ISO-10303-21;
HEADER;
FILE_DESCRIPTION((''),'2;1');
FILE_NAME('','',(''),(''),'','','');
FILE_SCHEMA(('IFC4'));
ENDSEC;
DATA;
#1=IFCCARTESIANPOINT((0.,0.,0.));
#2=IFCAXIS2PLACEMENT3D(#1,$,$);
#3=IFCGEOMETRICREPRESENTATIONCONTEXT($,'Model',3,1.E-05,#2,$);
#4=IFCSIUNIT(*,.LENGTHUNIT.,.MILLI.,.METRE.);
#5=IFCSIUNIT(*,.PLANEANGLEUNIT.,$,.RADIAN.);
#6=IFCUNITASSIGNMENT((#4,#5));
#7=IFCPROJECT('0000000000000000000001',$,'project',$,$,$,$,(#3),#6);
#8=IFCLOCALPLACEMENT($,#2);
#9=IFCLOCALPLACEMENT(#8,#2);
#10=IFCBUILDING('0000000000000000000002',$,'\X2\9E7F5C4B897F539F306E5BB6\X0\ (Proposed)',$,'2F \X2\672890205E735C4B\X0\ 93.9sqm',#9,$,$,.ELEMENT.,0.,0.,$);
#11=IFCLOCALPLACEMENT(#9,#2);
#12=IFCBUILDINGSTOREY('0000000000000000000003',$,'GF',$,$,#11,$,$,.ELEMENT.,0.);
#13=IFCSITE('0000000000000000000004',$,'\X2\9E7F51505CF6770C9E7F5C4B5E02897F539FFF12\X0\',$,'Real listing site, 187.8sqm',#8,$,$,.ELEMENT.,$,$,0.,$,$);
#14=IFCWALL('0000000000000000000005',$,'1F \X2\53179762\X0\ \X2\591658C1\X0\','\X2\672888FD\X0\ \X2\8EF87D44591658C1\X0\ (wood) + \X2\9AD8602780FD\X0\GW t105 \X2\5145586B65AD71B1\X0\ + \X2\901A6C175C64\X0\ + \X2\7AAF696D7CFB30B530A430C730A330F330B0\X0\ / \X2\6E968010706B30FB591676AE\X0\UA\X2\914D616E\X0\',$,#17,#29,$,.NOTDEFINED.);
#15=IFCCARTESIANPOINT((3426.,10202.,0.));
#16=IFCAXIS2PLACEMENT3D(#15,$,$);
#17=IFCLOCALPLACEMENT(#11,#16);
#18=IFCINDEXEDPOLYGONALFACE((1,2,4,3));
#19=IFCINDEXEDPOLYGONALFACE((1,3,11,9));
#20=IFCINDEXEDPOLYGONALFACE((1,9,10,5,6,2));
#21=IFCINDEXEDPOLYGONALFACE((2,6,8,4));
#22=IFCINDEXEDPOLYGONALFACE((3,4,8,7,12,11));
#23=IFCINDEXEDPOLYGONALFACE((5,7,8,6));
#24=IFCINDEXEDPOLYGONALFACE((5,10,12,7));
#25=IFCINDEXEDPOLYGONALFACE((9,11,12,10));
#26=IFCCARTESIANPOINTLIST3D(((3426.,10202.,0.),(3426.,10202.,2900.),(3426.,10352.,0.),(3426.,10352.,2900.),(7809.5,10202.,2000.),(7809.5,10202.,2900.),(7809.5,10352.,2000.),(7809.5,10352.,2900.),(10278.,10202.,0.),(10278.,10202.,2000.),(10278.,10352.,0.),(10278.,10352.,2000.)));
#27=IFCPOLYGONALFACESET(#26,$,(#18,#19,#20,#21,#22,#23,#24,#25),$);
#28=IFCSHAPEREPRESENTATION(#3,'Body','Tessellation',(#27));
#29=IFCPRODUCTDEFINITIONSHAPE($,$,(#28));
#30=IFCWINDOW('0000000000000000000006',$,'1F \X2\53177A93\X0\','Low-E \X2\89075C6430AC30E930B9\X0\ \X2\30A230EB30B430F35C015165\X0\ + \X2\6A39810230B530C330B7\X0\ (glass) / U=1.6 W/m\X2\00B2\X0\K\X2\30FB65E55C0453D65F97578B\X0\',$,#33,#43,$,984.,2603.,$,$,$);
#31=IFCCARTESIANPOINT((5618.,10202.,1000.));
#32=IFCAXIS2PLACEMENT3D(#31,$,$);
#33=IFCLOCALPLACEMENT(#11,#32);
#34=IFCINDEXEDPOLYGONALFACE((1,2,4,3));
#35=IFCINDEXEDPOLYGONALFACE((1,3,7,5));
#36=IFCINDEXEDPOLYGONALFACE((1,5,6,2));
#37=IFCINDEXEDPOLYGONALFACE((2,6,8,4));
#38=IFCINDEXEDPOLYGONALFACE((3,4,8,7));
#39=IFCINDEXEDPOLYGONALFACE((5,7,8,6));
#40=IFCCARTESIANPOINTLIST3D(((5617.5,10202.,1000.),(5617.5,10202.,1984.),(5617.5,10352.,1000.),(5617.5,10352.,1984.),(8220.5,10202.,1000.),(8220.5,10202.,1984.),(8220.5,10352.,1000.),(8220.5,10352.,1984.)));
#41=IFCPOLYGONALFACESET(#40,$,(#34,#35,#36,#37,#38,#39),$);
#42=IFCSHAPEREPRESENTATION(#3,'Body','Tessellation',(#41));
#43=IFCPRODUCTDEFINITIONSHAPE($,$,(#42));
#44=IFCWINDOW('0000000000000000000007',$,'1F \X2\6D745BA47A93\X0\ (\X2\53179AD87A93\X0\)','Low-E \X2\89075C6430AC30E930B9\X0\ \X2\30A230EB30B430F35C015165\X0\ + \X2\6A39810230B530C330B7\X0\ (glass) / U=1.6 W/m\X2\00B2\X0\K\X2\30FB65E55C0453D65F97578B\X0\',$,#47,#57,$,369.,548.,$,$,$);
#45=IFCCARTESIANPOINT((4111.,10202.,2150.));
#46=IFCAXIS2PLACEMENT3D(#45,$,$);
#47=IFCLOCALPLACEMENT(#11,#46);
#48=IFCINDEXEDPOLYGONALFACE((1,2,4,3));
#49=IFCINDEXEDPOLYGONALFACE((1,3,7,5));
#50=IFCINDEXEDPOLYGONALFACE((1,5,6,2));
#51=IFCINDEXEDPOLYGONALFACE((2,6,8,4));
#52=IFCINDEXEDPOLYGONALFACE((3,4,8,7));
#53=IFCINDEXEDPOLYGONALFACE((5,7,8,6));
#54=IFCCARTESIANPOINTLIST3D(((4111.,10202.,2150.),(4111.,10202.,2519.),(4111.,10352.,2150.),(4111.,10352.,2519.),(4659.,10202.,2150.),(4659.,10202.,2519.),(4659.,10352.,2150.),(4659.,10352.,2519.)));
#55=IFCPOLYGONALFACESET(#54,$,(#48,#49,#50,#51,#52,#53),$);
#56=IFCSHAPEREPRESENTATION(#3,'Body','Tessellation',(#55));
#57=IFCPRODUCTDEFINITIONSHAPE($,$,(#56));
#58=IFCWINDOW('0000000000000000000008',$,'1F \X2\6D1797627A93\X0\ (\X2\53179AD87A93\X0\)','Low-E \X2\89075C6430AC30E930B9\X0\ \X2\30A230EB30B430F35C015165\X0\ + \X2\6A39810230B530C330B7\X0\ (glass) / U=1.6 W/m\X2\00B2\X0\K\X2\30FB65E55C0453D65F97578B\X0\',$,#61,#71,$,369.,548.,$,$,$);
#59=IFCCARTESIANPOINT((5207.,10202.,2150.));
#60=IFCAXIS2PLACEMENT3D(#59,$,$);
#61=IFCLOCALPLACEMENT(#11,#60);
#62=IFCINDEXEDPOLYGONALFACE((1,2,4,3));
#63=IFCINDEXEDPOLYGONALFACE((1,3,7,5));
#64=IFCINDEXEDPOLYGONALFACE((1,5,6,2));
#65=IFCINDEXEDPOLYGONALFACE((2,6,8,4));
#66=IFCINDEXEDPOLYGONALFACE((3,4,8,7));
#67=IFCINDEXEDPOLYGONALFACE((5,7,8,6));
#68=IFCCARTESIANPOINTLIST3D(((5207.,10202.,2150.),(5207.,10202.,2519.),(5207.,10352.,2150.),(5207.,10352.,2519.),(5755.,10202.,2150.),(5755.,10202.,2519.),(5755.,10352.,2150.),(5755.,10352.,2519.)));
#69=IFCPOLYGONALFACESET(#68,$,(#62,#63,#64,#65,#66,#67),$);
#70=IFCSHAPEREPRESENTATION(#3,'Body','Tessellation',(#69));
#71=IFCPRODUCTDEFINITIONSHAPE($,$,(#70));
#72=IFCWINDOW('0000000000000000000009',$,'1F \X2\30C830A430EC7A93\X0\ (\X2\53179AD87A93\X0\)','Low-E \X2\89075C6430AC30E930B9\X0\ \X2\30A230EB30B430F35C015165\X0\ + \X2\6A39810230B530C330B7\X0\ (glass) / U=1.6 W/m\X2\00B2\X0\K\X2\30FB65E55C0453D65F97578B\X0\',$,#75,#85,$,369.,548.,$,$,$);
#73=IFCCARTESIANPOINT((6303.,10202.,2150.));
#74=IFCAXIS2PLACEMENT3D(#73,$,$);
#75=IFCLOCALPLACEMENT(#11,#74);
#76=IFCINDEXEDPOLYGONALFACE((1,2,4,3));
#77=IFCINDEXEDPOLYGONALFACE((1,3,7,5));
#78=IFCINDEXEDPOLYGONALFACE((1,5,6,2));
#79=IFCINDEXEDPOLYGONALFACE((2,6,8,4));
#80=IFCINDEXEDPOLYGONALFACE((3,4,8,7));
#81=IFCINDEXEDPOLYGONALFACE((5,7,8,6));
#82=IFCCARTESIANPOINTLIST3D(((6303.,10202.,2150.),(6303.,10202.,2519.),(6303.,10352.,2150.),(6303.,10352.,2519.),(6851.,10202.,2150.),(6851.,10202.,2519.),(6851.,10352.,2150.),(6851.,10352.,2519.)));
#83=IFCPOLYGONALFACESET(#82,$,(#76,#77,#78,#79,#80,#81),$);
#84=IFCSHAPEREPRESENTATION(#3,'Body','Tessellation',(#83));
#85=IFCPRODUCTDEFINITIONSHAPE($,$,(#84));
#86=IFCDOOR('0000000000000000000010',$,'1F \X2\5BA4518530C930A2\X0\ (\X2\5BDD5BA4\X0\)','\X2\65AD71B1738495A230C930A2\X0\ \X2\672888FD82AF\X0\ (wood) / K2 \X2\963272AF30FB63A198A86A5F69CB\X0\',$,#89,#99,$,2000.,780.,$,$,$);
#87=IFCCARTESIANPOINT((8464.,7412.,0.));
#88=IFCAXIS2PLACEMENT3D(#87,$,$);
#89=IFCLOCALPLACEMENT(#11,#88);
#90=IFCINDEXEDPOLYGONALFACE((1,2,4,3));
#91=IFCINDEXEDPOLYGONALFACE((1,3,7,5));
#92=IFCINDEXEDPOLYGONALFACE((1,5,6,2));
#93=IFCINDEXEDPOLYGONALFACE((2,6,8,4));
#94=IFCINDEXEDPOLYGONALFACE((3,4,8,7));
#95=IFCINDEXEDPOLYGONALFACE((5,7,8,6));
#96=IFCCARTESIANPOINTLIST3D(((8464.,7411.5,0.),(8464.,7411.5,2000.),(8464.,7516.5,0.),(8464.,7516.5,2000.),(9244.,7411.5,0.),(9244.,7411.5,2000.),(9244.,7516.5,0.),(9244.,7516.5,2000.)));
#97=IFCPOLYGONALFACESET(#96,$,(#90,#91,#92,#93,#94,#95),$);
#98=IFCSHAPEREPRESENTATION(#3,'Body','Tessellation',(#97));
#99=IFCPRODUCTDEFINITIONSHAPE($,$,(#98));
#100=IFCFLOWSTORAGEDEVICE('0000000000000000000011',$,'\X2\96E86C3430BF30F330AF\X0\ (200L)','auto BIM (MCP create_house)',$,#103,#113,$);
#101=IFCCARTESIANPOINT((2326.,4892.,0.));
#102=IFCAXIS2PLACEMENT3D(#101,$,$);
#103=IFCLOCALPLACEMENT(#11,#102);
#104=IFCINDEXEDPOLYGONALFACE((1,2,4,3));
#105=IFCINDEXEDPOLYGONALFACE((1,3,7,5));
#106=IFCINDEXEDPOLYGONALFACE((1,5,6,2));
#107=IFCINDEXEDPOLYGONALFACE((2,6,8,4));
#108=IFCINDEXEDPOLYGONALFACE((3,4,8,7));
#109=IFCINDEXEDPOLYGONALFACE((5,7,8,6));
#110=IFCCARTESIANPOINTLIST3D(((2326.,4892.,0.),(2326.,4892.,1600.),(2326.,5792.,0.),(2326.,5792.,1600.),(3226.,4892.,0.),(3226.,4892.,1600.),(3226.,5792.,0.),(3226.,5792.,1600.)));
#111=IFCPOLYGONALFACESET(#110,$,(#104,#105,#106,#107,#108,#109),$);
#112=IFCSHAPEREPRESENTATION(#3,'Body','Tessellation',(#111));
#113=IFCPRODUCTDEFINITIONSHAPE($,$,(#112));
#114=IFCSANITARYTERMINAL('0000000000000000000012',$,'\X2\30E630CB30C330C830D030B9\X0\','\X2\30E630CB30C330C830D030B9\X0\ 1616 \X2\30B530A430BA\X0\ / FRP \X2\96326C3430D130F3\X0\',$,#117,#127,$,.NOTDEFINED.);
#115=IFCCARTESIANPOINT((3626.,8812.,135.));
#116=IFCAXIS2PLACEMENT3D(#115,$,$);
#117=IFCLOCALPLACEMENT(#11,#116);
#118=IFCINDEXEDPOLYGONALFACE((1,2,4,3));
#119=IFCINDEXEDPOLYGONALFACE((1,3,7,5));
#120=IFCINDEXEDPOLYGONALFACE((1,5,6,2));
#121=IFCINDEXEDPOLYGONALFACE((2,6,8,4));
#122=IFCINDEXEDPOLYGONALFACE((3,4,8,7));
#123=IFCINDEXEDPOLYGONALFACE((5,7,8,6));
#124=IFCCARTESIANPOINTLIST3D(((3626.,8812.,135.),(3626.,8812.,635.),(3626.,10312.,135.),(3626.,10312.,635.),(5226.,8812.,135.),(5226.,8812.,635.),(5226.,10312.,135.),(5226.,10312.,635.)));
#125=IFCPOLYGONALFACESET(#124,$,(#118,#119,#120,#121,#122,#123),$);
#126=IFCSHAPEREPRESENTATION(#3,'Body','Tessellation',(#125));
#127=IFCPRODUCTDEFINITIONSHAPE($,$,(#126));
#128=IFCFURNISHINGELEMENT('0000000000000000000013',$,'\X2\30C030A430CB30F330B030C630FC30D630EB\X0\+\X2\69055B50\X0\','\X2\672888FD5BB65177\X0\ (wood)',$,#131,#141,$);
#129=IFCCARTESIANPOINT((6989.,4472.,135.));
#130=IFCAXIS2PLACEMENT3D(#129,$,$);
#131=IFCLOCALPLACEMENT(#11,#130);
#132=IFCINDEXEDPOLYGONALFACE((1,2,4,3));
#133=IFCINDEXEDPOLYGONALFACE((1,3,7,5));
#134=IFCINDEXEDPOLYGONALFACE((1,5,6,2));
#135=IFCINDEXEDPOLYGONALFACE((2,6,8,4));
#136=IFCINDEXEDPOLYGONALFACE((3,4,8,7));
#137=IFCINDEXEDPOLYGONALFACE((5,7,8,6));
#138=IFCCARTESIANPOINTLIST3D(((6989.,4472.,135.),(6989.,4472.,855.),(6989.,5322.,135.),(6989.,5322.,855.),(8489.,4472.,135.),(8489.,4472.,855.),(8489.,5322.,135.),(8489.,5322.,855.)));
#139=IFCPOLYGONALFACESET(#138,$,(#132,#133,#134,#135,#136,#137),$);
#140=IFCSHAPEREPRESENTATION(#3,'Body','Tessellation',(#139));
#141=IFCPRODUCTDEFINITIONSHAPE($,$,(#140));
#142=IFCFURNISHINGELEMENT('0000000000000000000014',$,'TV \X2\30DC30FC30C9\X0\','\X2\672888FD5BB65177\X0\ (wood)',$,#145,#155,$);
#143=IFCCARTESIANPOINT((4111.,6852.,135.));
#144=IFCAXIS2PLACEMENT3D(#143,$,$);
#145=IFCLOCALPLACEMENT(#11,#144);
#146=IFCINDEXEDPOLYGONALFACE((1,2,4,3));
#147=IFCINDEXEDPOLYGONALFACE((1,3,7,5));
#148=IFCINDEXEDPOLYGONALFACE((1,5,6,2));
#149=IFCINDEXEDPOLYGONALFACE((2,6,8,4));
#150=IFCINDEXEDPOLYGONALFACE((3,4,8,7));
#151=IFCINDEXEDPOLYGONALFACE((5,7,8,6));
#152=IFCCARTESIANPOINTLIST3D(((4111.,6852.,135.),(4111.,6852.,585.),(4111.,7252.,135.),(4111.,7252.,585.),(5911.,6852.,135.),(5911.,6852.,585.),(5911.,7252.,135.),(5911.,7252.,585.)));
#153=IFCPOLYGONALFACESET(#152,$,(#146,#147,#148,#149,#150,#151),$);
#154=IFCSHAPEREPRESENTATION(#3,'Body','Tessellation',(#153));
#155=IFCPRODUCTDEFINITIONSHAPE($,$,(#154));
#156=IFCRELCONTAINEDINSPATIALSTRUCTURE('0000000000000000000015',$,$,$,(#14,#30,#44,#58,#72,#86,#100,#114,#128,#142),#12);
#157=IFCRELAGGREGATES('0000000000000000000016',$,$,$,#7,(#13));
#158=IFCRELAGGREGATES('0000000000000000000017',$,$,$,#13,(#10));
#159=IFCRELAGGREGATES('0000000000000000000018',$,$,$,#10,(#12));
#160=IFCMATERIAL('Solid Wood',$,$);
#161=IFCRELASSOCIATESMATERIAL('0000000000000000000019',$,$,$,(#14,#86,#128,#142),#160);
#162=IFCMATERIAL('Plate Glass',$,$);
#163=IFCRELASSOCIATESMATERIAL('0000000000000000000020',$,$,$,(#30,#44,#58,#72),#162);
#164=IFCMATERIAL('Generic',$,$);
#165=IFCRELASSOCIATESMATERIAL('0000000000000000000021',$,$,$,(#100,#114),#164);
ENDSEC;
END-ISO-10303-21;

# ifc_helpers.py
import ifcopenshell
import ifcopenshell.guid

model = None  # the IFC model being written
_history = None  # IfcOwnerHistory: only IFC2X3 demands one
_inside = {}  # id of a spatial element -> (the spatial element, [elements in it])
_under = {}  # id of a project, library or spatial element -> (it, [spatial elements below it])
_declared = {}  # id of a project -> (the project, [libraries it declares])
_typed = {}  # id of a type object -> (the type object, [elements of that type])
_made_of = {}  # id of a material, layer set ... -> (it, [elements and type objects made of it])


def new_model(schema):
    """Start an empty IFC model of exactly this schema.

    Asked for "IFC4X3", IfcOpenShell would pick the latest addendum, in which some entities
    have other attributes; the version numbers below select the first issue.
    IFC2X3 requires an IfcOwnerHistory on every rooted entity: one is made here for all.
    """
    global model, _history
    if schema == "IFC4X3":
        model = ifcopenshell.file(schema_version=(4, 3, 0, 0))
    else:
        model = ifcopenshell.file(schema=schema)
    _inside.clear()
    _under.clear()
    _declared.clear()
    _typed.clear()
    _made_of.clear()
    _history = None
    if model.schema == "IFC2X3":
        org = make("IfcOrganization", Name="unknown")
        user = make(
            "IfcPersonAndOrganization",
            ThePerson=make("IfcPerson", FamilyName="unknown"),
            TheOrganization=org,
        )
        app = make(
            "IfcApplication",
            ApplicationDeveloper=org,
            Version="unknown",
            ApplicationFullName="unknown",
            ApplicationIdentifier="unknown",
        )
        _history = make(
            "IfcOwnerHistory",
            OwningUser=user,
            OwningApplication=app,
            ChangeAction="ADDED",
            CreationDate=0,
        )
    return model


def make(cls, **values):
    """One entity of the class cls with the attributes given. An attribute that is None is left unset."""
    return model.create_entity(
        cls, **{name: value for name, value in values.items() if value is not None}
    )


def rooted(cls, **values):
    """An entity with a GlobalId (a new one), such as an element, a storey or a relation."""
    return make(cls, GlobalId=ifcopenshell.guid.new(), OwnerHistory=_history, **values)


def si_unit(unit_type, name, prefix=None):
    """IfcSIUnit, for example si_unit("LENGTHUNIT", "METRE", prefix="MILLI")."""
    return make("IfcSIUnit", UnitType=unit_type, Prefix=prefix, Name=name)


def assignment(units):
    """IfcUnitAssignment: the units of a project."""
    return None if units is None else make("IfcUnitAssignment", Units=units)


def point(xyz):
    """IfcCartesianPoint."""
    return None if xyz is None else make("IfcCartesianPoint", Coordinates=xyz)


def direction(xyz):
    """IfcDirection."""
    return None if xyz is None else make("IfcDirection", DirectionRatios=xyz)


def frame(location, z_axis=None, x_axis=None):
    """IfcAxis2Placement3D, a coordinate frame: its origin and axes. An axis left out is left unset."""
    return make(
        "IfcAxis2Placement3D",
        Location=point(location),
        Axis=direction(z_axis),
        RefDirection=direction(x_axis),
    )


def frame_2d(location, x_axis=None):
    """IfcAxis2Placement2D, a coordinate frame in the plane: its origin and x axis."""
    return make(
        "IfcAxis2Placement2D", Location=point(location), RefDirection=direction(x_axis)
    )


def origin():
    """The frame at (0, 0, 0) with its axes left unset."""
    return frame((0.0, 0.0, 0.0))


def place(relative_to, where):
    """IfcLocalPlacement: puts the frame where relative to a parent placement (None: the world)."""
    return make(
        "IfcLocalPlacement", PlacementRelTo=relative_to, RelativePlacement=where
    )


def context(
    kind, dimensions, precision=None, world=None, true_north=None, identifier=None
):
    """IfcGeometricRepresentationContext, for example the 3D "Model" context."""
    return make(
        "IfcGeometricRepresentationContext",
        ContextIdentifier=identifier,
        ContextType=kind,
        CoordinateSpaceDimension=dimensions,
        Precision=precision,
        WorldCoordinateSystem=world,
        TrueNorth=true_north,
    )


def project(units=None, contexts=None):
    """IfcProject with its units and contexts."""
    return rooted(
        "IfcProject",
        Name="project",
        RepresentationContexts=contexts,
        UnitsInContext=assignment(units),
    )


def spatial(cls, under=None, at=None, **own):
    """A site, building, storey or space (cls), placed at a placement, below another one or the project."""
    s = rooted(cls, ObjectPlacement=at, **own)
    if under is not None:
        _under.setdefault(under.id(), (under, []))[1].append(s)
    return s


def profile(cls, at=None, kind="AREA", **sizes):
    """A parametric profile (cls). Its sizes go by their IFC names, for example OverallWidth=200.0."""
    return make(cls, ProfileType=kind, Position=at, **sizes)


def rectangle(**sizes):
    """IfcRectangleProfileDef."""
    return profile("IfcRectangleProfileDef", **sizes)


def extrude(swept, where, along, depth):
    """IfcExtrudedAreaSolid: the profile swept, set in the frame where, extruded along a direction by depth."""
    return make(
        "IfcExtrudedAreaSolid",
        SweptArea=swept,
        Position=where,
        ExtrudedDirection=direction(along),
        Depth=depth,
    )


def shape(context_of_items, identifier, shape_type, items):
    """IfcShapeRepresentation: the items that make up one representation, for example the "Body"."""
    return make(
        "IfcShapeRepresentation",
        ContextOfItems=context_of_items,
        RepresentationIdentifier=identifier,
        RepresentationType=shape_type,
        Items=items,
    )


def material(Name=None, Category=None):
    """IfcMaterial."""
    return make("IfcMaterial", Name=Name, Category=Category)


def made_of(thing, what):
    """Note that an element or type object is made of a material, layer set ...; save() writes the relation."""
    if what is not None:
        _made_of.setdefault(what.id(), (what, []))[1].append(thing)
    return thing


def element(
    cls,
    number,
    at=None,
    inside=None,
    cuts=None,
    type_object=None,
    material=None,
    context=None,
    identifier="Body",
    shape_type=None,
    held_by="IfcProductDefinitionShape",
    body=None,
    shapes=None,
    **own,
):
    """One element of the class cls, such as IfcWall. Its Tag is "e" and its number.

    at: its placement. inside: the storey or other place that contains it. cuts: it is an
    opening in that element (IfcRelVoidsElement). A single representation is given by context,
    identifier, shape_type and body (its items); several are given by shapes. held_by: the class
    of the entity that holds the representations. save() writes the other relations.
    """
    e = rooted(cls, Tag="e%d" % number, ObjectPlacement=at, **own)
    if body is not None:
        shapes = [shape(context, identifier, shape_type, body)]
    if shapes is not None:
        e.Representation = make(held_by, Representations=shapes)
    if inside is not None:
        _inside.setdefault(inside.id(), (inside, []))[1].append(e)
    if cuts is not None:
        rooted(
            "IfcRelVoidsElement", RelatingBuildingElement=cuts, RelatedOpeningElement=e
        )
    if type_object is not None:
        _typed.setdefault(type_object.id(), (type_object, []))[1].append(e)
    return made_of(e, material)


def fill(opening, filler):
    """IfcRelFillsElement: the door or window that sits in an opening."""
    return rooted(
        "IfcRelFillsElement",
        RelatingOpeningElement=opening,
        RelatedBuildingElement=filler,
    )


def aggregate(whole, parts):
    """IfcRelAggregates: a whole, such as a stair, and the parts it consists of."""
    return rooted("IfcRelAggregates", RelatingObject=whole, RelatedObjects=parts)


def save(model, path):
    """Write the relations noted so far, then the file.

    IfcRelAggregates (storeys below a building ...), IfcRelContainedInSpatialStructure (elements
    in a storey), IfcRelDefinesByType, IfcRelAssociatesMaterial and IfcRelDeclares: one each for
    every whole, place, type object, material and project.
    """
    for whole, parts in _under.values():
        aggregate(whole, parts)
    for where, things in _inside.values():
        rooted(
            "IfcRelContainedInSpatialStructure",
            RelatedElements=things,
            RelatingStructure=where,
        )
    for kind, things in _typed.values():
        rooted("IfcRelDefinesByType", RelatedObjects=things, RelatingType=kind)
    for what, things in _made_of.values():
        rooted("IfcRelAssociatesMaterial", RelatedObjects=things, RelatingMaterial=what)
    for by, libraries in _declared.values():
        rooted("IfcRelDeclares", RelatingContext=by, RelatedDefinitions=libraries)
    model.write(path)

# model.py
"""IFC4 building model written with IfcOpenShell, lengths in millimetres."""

from ifc_helpers import new_model, si_unit, frame, frame_2d, origin, place, context, project, spatial, rectangle, extrude, material, element, fill, save


model = new_model("IFC4")

# Units and contexts
model_context = context("Model", 3, precision=1e-05, world=origin())
ifc_project = project(units=[si_unit("LENGTHUNIT", "METRE", prefix="MILLI"), si_unit("PLANEANGLEUNIT", "RADIAN")], contexts=[model_context])

# Site, building, storey
site_placement = place(None, origin())
site = spatial("IfcSite", under=ifc_project, at=site_placement, Name="鹿児島県鹿屋市西原２", ObjectType="Real listing site, 187.8sqm", CompositionType="ELEMENT", RefElevation=0.0)
building_placement = place(site_placement, origin())
building = spatial("IfcBuilding", under=site, at=building_placement, Name="鹿屋西原の家 (Proposed)", ObjectType="2F 木造平屋 93.9sqm", CompositionType="ELEMENT", ElevationOfRefHeight=0.0, ElevationOfTerrain=0.0)
storey_placement = place(building_placement, origin())
storey = spatial("IfcBuildingStorey", under=building, at=storey_placement, Name="GF", CompositionType="ELEMENT", Elevation=0.0)

# Wall, openings, windows
ifc_material_1 = material(Name="Solid Wood")
wall_1_placement = place(storey_placement, frame((3426.0, 10202.0, 0.0)))
wall_1 = element("IfcWall", 1, at=wall_1_placement, inside=storey, material=ifc_material_1, Name="1F 北面 外壁", Description="木製 軸組外壁 (wood) + 高性能GW t105 充填断熱 + 通気層 + 窯業系サイディング / 準耐火・外皮UA配慮", PredefinedType="NOTDEFINED", context=model_context, shape_type="SweptSolid", body=[
    extrude(rectangle(XDim=6852.0, YDim=150.0, at=frame_2d((3426.0, 75.0))), frame((3426.0, 10202.0, 0.0)), (0.0, 0.0, 1.0), 2900.0),
])
opening_1_placement = place(storey_placement, frame((5618.0, 10202.0, 1000.0)))
opening_1 = element("IfcOpeningElement", 2, at=opening_1_placement, cuts=wall_1, PredefinedType="NOTDEFINED", context=model_context, shape_type="SweptSolid", body=[
    extrude(rectangle(XDim=2603.0, YDim=150.0, at=frame_2d((1301.0, 75.0))), frame((5618.0, 10202.0, 1000.0)), (0.0, 0.0, 1.0), 984.0),
])
opening_2_placement = place(storey_placement, frame((4111.0, 10202.0, 2150.0)))
opening_2 = element("IfcOpeningElement", 3, at=opening_2_placement, cuts=wall_1, PredefinedType="NOTDEFINED", context=model_context, shape_type="SweptSolid", body=[
    extrude(rectangle(XDim=548.0, YDim=150.0, at=frame_2d((274.0, 75.0))), frame((4111.0, 10202.0, 2150.0)), (0.0, 0.0, 1.0), 369.0),
])
opening_3_placement = place(storey_placement, frame((5207.0, 10202.0, 2150.0)))
opening_3 = element("IfcOpeningElement", 4, at=opening_3_placement, cuts=wall_1, PredefinedType="NOTDEFINED", context=model_context, shape_type="SweptSolid", body=[
    extrude(rectangle(XDim=548.0, YDim=150.0, at=frame_2d((274.0, 75.0))), frame((5207.0, 10202.0, 2150.0)), (0.0, 0.0, 1.0), 369.0),
])
opening_4_placement = place(storey_placement, frame((6303.0, 10202.0, 2150.0)))
opening_4 = element("IfcOpeningElement", 5, at=opening_4_placement, cuts=wall_1, PredefinedType="NOTDEFINED", context=model_context, shape_type="SweptSolid", body=[
    extrude(rectangle(XDim=548.0, YDim=150.0, at=frame_2d((274.0, 75.0))), frame((6303.0, 10202.0, 2150.0)), (0.0, 0.0, 1.0), 369.0),
])
ifc_material_2 = material(Name="Plate Glass")
window_1_placement = place(storey_placement, frame((5618.0, 10202.0, 1000.0)))
window_1 = element("IfcWindow", 6, at=window_1_placement, inside=storey, material=ifc_material_2, Name="1F 北窓", Description="Low-E 複層ガラス アルゴン封入 + 樹脂サッシ (glass) / U=1.6 W/m²K・日射取得型", OverallHeight=984.0, OverallWidth=2603.0, context=model_context, shape_type="SweptSolid", body=[
    extrude(rectangle(XDim=2603.0, YDim=150.0, at=frame_2d((1301.0, 75.0))), frame((5618.0, 10202.0, 1000.0)), (0.0, 0.0, 1.0), 984.0),
])
fill(opening_1, window_1)
window_2_placement = place(storey_placement, frame((4111.0, 10202.0, 2150.0)))
window_2 = element("IfcWindow", 7, at=window_2_placement, inside=storey, material=ifc_material_2, Name="1F 浴室窓 (北高窓)", Description="Low-E 複層ガラス アルゴン封入 + 樹脂サッシ (glass) / U=1.6 W/m²K・日射取得型", OverallHeight=369.0, OverallWidth=548.0, context=model_context, shape_type="SweptSolid", body=[
    extrude(rectangle(XDim=548.0, YDim=150.0, at=frame_2d((274.0, 75.0))), frame((4111.0, 10202.0, 2150.0)), (0.0, 0.0, 1.0), 369.0),
])
fill(opening_2, window_2)
window_3_placement = place(storey_placement, frame((5207.0, 10202.0, 2150.0)))
window_3 = element("IfcWindow", 8, at=window_3_placement, inside=storey, material=ifc_material_2, Name="1F 洗面窓 (北高窓)", Description="Low-E 複層ガラス アルゴン封入 + 樹脂サッシ (glass) / U=1.6 W/m²K・日射取得型", OverallHeight=369.0, OverallWidth=548.0, context=model_context, shape_type="SweptSolid", body=[
    extrude(rectangle(XDim=548.0, YDim=150.0, at=frame_2d((274.0, 75.0))), frame((5207.0, 10202.0, 2150.0)), (0.0, 0.0, 1.0), 369.0),
])
fill(opening_3, window_3)
window_4_placement = place(storey_placement, frame((6303.0, 10202.0, 2150.0)))
window_4 = element("IfcWindow", 9, at=window_4_placement, inside=storey, material=ifc_material_2, Name="1F トイレ窓 (北高窓)", Description="Low-E 複層ガラス アルゴン封入 + 樹脂サッシ (glass) / U=1.6 W/m²K・日射取得型", OverallHeight=369.0, OverallWidth=548.0, context=model_context, shape_type="SweptSolid", body=[
    extrude(rectangle(XDim=548.0, YDim=150.0, at=frame_2d((274.0, 75.0))), frame((6303.0, 10202.0, 2150.0)), (0.0, 0.0, 1.0), 369.0),
])
fill(opening_4, window_4)

# Door
door_1_placement = place(storey_placement, frame((8464.0, 7412.0, 0.0)))
element("IfcDoor", 10, at=door_1_placement, inside=storey, material=ifc_material_1, Name="1F 室内ドア (寝室)", Description="断熱玄関ドア 木製芯 (wood) / K2 防犯・採風機構", OverallHeight=2000.0, OverallWidth=780.0, context=model_context, shape_type="SweptSolid", body=[
    extrude(rectangle(XDim=780.0, YDim=105.0, at=frame_2d((390.0, 52.0))), frame((8464.0, 7412.0, 0.0)), (0.0, 0.0, 1.0), 2000.0),
])

# Flow storage device
ifc_material_3 = material(Name="Generic")
flow_storage_device_placement = place(storey_placement, frame((2326.0, 4892.0, 0.0)))
element("IfcFlowStorageDevice", 11, at=flow_storage_device_placement, inside=storey, material=ifc_material_3, Name="雨水タンク (200L)", Description="auto BIM (MCP create_house)", context=model_context, shape_type="SweptSolid", body=[
    extrude(rectangle(XDim=900.0, YDim=900.0, at=frame_2d((450.0, 450.0))), frame((2326.0, 4892.0, 0.0)), (0.0, 0.0, 1.0), 1600.0),
])

# Sanitary terminal
sanitary_terminal_placement = place(storey_placement, frame((3626.0, 8812.0, 135.0)))
element("IfcSanitaryTerminal", 12, at=sanitary_terminal_placement, inside=storey, material=ifc_material_3, Name="ユニットバス", Description="ユニットバス 1616 サイズ / FRP 防水パン", PredefinedType="NOTDEFINED", context=model_context, shape_type="SweptSolid", body=[
    extrude(rectangle(XDim=1600.0, YDim=1500.0, at=frame_2d((800.0, 750.0))), frame((3626.0, 8812.0, 135.0)), (0.0, 0.0, 1.0), 500.0),
])

# Furnishing elements
furnishing_1_placement = place(storey_placement, frame((6989.0, 4472.0, 135.0)))
element("IfcFurnishingElement", 13, at=furnishing_1_placement, inside=storey, material=ifc_material_1, Name="ダイニングテーブル+椅子", Description="木製家具 (wood)", context=model_context, shape_type="SweptSolid", body=[
    extrude(rectangle(XDim=1500.0, YDim=850.0, at=frame_2d((750.0, 425.0))), frame((6989.0, 4472.0, 135.0)), (0.0, 0.0, 1.0), 720.0),
])
furnishing_2_placement = place(storey_placement, frame((4111.0, 6852.0, 135.0)))
element("IfcFurnishingElement", 14, at=furnishing_2_placement, inside=storey, material=ifc_material_1, Name="TV ボード", Description="木製家具 (wood)", context=model_context, shape_type="SweptSolid", body=[
    extrude(rectangle(XDim=1800.0, YDim=400.0, at=frame_2d((900.0, 200.0))), frame((4111.0, 6852.0, 135.0)), (0.0, 0.0, 1.0), 450.0),
])

save(model, "model.ifc")
